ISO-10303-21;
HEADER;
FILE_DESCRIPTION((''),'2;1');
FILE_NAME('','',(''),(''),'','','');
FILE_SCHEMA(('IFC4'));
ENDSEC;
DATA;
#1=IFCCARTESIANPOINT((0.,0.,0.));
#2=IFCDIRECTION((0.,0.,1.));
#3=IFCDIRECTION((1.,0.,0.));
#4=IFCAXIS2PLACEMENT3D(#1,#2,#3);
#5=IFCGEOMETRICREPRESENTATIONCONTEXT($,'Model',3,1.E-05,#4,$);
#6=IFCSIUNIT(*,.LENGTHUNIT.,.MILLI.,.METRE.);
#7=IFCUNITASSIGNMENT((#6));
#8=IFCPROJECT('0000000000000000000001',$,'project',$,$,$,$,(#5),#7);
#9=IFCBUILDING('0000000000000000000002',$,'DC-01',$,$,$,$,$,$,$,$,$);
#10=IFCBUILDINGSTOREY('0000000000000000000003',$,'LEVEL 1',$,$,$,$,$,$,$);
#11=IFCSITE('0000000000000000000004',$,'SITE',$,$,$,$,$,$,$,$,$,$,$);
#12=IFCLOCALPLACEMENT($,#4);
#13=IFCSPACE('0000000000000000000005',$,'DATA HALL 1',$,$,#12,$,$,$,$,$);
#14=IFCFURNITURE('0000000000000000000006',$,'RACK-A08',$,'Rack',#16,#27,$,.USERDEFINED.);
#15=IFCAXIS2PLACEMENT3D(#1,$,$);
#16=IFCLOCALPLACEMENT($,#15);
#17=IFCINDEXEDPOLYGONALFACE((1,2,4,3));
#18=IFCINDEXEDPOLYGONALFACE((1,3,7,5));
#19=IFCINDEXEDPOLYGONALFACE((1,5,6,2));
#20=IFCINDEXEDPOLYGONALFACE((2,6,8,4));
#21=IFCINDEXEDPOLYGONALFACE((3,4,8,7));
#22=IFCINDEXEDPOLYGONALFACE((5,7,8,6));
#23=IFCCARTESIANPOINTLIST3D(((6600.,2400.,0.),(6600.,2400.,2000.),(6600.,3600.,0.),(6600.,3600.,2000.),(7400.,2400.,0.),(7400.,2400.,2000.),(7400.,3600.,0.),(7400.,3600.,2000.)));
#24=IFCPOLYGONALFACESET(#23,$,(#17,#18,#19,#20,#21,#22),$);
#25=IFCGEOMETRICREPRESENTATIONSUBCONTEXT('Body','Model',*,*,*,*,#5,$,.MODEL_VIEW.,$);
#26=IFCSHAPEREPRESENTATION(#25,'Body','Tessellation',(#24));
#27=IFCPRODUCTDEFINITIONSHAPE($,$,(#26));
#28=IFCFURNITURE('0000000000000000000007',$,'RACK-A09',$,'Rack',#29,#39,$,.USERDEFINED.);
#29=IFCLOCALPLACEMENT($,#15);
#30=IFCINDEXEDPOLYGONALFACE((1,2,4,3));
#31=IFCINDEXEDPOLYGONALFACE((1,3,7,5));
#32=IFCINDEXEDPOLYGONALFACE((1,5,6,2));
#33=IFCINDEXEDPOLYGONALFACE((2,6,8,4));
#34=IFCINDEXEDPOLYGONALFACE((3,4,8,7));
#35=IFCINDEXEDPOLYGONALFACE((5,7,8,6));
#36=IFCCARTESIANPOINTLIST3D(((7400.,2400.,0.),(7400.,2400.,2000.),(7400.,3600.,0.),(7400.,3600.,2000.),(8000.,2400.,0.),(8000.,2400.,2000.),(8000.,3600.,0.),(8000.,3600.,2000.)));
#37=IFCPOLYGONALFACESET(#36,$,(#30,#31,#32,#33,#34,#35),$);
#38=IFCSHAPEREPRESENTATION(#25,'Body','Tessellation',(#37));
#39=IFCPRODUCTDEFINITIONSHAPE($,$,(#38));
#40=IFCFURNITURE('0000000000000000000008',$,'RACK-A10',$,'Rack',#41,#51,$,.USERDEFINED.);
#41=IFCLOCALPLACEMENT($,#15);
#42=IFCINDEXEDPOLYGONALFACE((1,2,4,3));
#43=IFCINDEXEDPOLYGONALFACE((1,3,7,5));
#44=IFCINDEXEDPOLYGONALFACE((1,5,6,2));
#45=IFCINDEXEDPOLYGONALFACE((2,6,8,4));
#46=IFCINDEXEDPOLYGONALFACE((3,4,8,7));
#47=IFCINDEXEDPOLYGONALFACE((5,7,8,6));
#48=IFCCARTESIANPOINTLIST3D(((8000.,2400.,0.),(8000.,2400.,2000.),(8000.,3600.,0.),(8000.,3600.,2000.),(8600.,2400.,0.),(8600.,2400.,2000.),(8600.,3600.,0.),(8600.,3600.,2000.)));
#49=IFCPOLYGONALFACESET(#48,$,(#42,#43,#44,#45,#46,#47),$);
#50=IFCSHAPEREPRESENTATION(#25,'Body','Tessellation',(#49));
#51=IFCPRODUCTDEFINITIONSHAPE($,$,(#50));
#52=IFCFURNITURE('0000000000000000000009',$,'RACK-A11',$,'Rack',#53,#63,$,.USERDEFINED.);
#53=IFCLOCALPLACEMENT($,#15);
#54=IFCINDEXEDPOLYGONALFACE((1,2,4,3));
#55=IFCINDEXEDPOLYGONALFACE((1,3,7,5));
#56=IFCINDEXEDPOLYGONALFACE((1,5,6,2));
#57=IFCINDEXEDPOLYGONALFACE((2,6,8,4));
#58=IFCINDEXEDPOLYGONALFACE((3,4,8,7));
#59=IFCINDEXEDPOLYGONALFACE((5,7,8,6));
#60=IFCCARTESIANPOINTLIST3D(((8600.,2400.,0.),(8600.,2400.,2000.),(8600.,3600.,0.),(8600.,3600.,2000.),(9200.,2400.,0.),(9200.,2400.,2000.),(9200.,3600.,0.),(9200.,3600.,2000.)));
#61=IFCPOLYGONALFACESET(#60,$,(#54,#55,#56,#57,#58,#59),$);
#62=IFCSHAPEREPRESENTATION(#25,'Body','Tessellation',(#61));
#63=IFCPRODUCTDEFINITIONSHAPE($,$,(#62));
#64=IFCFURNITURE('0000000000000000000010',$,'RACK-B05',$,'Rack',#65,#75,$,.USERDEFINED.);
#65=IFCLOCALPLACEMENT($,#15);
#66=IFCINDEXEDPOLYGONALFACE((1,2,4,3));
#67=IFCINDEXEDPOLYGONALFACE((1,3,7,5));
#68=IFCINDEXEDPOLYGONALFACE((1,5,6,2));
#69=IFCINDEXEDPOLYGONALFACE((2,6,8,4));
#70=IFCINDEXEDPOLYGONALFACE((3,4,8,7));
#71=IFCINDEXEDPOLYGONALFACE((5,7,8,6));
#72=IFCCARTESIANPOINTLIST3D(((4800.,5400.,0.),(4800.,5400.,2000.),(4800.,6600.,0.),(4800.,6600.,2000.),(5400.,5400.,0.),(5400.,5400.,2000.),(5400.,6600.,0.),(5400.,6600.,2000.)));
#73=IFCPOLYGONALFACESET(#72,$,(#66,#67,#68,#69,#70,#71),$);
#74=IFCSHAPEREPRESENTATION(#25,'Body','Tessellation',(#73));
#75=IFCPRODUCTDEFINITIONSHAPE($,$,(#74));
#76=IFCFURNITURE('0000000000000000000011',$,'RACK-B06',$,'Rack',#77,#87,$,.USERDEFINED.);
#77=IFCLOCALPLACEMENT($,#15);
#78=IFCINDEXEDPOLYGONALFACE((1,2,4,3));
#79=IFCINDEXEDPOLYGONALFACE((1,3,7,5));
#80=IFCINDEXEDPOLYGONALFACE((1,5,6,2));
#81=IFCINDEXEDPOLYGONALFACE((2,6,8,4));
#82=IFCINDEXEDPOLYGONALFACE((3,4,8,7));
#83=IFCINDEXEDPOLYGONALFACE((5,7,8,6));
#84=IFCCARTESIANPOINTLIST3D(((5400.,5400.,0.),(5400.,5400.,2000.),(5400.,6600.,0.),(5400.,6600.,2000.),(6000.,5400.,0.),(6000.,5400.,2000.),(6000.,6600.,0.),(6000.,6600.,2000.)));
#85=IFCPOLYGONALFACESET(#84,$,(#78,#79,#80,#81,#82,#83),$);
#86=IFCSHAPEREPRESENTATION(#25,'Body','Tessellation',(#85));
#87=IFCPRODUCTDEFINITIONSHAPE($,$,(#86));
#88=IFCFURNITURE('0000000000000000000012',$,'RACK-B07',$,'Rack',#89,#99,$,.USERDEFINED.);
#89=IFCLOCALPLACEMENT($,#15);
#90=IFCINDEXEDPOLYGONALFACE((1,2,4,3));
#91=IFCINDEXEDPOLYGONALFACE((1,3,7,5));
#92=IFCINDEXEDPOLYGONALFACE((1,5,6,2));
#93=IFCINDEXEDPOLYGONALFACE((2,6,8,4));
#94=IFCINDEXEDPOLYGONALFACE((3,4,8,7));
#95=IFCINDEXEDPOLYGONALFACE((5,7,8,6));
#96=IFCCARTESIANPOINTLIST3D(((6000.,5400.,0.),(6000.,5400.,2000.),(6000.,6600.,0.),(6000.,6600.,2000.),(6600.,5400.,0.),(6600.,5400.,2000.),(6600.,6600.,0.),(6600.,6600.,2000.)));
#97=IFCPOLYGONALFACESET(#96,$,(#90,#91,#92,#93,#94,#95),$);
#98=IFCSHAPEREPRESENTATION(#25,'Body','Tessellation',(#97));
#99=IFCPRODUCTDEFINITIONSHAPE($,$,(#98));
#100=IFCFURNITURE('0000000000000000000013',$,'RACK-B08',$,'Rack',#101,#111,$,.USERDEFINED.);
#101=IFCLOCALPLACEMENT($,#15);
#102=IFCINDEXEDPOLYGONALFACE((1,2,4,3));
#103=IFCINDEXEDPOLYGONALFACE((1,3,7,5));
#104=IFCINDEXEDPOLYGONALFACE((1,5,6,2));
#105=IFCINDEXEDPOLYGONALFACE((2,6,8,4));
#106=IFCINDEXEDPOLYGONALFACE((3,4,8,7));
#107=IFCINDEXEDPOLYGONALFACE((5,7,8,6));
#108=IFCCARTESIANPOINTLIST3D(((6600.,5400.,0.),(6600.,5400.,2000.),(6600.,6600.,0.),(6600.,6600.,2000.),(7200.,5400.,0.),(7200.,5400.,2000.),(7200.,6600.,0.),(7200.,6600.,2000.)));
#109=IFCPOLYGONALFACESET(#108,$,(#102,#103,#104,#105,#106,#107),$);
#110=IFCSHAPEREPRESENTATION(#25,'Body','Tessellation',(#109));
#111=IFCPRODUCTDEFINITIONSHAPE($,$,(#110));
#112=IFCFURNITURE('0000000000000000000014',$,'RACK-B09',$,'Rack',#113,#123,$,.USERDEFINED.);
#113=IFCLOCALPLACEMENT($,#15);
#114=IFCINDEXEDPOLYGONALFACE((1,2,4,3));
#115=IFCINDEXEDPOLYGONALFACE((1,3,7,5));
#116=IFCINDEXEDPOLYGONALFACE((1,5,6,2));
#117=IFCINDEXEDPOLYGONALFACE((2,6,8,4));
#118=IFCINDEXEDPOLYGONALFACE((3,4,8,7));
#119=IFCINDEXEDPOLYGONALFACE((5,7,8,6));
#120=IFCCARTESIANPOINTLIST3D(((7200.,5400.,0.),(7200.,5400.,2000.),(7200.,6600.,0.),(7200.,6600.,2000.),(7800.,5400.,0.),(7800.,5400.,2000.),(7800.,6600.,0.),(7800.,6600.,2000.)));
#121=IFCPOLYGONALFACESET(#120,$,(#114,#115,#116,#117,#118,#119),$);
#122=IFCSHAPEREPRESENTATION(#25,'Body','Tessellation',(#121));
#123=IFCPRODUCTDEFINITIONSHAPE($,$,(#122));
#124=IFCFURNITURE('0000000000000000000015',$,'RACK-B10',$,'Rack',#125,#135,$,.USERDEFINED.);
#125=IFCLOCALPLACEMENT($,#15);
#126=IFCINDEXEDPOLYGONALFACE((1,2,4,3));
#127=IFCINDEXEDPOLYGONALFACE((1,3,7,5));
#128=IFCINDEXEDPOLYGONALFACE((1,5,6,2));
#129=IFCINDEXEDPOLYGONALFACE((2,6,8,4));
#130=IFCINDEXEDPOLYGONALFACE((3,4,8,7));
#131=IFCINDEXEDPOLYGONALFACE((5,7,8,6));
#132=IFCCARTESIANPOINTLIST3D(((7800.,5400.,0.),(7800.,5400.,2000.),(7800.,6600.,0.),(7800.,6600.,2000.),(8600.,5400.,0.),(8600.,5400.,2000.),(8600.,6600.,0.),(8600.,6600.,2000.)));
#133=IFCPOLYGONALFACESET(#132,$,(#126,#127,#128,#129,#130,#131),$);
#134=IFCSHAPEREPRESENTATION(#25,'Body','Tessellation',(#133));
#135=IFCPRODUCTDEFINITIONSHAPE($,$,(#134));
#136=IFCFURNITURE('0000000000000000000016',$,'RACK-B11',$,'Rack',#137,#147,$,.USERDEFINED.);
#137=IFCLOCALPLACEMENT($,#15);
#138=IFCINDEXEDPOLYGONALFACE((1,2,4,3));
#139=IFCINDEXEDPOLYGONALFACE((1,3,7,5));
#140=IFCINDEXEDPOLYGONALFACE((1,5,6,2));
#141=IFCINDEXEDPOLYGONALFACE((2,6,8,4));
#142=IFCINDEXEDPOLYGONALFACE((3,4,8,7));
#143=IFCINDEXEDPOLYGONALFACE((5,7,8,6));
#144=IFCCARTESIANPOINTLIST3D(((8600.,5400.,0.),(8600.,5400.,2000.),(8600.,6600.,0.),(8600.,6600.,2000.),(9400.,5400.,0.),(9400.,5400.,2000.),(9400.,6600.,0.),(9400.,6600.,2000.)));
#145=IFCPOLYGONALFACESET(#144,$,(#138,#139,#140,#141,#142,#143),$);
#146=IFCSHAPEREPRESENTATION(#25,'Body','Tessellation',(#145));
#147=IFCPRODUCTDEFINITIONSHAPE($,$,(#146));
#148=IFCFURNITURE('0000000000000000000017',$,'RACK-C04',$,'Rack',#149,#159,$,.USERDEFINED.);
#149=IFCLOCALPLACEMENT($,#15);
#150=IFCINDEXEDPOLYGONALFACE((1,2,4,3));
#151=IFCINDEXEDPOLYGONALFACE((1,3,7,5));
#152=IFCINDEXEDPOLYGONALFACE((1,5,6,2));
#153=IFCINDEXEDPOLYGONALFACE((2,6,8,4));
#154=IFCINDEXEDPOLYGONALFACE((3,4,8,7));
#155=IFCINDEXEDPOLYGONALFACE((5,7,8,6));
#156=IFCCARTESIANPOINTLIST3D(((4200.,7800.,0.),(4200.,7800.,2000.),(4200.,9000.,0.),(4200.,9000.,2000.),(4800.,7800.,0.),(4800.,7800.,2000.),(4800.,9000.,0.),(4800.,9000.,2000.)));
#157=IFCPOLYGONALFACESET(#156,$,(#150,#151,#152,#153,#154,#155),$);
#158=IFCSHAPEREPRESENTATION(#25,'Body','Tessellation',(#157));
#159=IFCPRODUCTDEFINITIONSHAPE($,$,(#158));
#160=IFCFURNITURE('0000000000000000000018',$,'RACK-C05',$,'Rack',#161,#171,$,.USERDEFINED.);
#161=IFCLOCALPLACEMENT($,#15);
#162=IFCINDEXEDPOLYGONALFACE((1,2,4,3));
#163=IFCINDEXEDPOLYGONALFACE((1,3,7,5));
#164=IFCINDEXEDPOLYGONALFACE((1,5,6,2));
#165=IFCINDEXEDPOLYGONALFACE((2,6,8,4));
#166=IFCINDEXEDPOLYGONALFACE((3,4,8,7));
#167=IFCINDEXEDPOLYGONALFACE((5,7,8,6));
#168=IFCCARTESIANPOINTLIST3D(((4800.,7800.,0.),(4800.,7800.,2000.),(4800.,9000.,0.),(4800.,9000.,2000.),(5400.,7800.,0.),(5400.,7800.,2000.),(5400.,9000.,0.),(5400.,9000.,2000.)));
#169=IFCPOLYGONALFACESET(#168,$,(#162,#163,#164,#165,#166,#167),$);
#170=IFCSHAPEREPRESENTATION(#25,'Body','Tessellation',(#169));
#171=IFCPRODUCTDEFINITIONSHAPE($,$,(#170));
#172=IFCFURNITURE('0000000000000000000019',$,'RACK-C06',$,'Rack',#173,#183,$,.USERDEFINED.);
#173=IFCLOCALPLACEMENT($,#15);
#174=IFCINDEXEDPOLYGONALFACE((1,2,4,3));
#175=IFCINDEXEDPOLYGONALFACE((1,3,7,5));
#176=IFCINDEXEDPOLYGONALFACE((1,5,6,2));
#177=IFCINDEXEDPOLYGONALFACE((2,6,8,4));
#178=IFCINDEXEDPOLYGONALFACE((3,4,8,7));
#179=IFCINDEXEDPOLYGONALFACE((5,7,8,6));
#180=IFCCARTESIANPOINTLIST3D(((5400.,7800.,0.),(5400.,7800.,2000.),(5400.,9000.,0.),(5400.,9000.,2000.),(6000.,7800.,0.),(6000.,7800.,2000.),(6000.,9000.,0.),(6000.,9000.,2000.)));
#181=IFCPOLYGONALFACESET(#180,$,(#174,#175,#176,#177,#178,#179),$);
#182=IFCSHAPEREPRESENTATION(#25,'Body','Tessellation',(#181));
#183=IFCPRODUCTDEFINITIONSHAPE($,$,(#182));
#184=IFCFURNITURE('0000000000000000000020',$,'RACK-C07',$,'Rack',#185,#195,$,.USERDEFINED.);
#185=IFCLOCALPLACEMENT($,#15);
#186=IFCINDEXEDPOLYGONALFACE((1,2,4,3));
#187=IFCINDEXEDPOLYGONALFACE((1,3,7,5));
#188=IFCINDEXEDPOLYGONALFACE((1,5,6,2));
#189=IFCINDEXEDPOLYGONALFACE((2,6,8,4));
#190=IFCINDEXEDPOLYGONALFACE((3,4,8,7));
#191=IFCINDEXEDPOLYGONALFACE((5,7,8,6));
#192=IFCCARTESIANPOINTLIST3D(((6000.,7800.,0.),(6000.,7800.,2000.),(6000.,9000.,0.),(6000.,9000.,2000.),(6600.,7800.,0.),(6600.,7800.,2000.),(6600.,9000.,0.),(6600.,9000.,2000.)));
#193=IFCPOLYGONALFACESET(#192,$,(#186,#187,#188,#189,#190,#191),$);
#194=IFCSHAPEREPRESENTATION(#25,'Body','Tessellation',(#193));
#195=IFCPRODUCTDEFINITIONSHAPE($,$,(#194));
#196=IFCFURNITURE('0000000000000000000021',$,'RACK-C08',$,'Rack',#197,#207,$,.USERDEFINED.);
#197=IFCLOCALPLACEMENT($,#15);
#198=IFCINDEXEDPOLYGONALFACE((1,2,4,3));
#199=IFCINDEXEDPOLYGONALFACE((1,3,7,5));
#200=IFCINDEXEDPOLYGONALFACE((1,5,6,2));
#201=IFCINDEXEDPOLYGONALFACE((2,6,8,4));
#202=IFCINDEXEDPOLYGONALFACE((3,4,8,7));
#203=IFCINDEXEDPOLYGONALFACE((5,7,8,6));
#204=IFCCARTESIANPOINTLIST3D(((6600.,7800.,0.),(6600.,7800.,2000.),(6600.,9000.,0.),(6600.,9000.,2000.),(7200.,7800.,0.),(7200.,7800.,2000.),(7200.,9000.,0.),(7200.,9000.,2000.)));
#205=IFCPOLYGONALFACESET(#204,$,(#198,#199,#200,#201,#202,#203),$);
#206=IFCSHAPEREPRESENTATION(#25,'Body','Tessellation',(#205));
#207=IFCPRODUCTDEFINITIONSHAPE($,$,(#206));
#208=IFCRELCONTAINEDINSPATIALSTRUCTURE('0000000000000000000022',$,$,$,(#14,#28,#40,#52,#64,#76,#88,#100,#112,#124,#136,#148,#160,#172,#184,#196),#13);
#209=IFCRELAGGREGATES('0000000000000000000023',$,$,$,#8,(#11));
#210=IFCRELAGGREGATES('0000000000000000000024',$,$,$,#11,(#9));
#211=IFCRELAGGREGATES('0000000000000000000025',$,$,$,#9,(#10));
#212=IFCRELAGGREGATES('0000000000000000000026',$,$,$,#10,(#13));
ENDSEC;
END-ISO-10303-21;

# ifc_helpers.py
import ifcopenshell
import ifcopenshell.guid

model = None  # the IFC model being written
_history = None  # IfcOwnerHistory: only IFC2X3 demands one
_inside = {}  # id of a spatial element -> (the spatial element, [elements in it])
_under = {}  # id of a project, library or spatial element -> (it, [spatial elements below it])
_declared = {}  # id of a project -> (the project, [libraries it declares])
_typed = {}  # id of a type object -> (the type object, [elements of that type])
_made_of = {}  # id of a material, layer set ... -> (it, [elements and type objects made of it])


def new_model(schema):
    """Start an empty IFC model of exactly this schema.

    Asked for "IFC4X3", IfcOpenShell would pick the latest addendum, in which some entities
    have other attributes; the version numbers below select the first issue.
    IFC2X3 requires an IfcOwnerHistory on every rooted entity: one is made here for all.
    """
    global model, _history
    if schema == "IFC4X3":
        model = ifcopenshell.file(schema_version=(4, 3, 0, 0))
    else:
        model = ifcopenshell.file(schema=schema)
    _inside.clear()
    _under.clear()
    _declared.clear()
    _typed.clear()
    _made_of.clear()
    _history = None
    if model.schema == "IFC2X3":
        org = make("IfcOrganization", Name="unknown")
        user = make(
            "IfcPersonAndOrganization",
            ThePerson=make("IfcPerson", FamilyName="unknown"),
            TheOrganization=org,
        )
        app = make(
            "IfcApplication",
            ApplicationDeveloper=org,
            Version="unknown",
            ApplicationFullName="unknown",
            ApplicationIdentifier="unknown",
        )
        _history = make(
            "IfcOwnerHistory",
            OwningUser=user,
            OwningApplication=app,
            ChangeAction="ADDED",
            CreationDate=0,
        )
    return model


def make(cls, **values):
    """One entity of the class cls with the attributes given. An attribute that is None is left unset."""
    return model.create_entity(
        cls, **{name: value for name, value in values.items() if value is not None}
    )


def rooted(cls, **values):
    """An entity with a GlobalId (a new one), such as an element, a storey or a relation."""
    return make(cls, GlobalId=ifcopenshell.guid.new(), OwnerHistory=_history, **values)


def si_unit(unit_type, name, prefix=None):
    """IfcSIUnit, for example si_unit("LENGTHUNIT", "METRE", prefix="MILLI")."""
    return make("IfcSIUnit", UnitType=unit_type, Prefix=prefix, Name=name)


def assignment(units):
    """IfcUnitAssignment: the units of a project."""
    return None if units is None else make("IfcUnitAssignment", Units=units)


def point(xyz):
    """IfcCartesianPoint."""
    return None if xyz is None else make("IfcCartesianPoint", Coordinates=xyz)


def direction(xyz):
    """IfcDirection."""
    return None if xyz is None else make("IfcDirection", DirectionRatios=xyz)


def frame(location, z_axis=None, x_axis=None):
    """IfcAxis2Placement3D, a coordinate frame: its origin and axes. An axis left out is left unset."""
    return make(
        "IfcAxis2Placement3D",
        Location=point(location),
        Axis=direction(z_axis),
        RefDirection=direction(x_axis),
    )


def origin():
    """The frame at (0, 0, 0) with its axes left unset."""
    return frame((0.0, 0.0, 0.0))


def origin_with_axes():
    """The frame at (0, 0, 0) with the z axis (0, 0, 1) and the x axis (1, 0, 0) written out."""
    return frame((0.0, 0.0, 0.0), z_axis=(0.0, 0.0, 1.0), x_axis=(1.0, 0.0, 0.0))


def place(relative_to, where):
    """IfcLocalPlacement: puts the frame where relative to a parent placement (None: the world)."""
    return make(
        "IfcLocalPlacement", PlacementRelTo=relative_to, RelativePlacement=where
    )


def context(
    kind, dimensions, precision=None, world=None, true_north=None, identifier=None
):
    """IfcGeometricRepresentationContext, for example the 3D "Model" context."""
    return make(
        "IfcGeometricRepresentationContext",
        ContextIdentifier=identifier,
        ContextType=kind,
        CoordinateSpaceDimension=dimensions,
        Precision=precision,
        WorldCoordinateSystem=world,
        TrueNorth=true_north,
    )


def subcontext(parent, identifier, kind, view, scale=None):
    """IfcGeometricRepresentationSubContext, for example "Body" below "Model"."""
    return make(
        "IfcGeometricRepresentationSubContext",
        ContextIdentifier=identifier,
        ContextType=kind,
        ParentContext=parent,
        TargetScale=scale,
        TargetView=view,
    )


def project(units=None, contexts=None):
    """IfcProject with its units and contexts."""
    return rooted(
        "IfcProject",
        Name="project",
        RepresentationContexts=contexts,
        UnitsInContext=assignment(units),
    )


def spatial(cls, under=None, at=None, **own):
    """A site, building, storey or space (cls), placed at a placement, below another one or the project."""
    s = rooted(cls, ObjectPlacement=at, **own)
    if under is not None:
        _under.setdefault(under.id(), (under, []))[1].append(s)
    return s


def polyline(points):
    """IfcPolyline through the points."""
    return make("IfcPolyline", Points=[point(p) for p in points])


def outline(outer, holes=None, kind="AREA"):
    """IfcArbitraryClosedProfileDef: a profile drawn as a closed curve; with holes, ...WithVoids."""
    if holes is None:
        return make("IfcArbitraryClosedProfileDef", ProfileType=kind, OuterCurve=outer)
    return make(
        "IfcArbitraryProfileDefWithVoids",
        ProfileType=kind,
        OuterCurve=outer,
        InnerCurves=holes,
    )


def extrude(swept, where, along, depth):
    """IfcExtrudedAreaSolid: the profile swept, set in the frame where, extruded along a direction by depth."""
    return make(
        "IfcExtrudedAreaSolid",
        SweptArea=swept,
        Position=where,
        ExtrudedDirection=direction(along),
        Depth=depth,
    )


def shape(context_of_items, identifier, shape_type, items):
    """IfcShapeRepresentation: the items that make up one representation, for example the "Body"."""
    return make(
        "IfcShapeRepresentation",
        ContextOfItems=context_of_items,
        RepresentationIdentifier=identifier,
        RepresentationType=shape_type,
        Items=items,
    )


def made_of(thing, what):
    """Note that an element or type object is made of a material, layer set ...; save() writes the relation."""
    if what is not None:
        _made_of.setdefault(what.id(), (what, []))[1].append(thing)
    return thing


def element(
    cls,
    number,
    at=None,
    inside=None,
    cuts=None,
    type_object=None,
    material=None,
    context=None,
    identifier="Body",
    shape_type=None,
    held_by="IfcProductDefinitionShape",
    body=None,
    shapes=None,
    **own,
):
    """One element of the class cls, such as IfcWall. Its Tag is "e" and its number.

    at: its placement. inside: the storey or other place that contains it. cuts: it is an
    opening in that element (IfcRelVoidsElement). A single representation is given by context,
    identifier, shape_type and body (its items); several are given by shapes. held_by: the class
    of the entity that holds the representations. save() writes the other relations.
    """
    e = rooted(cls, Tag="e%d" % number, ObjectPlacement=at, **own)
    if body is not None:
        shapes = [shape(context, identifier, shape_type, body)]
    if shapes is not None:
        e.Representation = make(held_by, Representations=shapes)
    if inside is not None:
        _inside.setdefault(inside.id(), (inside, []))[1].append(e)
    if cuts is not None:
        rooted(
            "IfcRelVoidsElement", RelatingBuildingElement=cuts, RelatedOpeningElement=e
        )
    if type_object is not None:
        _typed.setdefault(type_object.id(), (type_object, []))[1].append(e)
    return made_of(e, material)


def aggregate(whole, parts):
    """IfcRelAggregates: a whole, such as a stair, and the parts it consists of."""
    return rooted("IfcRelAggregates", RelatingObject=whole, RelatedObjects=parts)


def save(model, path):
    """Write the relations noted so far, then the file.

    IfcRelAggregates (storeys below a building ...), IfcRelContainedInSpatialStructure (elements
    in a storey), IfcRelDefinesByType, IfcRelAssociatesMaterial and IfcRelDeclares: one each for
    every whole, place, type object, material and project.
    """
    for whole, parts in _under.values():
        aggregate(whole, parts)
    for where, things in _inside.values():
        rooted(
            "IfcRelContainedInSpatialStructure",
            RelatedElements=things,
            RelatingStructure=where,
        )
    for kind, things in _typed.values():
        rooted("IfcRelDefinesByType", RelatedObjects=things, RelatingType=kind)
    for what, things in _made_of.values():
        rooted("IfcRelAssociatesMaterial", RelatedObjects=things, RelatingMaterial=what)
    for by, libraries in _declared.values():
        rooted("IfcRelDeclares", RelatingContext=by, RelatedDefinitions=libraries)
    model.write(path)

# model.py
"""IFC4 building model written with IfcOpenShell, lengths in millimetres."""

from ifc_helpers import new_model, si_unit, frame, origin, origin_with_axes, place, context, subcontext, project, spatial, polyline, outline, extrude, element, save


model = new_model("IFC4")

# Units and contexts
model_context = context("Model", 3, precision=1e-05, world=origin_with_axes())
body_context = subcontext(model_context, "Body", "Model", "MODEL_VIEW")
ifc_project = project(units=[si_unit("LENGTHUNIT", "METRE", prefix="MILLI")], contexts=[model_context])

# Site, building, storey, space
site = spatial("IfcSite", under=ifc_project, Name="SITE")
building = spatial("IfcBuilding", under=site, Name="DC-01")
storey = spatial("IfcBuildingStorey", under=building, Name="LEVEL 1")
space_placement = place(None, origin_with_axes())
space = spatial("IfcSpace", under=storey, at=space_placement, Name="DATA HALL 1")

# Furniture
furniture_placement = place(space_placement, frame((7400.0, 3600.0, 0.0), z_axis=(0.0, 0.0, 1.0), x_axis=(-1.0, 0.0, 0.0)))
element("IfcFurniture", 1, at=furniture_placement, inside=space, Name="RACK-A08", ObjectType="Rack", PredefinedType="USERDEFINED", context=body_context, shape_type="SweptSolid", body=[
    extrude(outline(polyline([(0.0, 0.0), (800.0, 0.0), (800.0, 1200.0), (0.0, 1200.0), (0.0, 0.0)])), origin(), (0.0, 0.0, 1.0), 2000.0),
])
for number, where, z_axis, x_axis, name in (
    (2, (8000.0, 3600.0, 0.0), (0.0, 0.0, 1.0), (-1.0, 0.0, 0.0), "RACK-A09"),
    (3, (8600.0, 3600.0, 0.0), (0.0, 0.0, 1.0), (-1.0, 0.0, 0.0), "RACK-A10"),
    (4, (9200.0, 3600.0, 0.0), (0.0, 0.0, 1.0), (-1.0, 0.0, 0.0), "RACK-A11"),
    (5, (4800.0, 5400.0, 0.0), (0.0, 0.0, 1.0), (1.0, 0.0, 0.0), "RACK-B05"),
    (6, (5400.0, 5400.0, 0.0), (0.0, 0.0, 1.0), (1.0, 0.0, 0.0), "RACK-B06"),
    (7, (6000.0, 5400.0, 0.0), (0.0, 0.0, 1.0), (1.0, 0.0, 0.0), "RACK-B07"),
    (8, (6600.0, 5400.0, 0.0), (0.0, 0.0, 1.0), (1.0, 0.0, 0.0), "RACK-B08"),
    (9, (7200.0, 5400.0, 0.0), (0.0, 0.0, 1.0), (1.0, 0.0, 0.0), "RACK-B09"),
):
    element("IfcFurniture", number, at=place(space_placement, frame(where, z_axis=z_axis, x_axis=x_axis)), inside=space, Name=name, ObjectType="Rack", PredefinedType="USERDEFINED", context=body_context, shape_type="SweptSolid", body=[
        extrude(outline(polyline([(0.0, 0.0), (600.0, 0.0), (600.0, 1200.0), (0.0, 1200.0), (0.0, 0.0)])), origin(), (0.0, 0.0, 1.0), 2000.0),
    ])
for number, where, z_axis, x_axis, name in (
    (10, (7800.0, 5400.0, 0.0), (0.0, 0.0, 1.0), (1.0, 0.0, 0.0), "RACK-B10"),
    (11, (8600.0, 5400.0, 0.0), (0.0, 0.0, 1.0), (1.0, 0.0, 0.0), "RACK-B11"),
):
    element("IfcFurniture", number, at=place(space_placement, frame(where, z_axis=z_axis, x_axis=x_axis)), inside=space, Name=name, ObjectType="Rack", PredefinedType="USERDEFINED", context=body_context, shape_type="SweptSolid", body=[
        extrude(outline(polyline([(0.0, 0.0), (800.0, 0.0), (800.0, 1200.0), (0.0, 1200.0), (0.0, 0.0)])), origin(), (0.0, 0.0, 1.0), 2000.0),
    ])
for number, where, z_axis, x_axis, name in (
    (12, (4800.0, 9000.0, 0.0), (0.0, 0.0, 1.0), (-1.0, 0.0, 0.0), "RACK-C04"),
    (13, (5400.0, 9000.0, 0.0), (0.0, 0.0, 1.0), (-1.0, 0.0, 0.0), "RACK-C05"),
    (14, (6000.0, 9000.0, 0.0), (0.0, 0.0, 1.0), (-1.0, 0.0, 0.0), "RACK-C06"),
    (15, (6600.0, 9000.0, 0.0), (0.0, 0.0, 1.0), (-1.0, 0.0, 0.0), "RACK-C07"),
    (16, (7200.0, 9000.0, 0.0), (0.0, 0.0, 1.0), (-1.0, 0.0, 0.0), "RACK-C08"),
):
    element("IfcFurniture", number, at=place(space_placement, frame(where, z_axis=z_axis, x_axis=x_axis)), inside=space, Name=name, ObjectType="Rack", PredefinedType="USERDEFINED", context=body_context, shape_type="SweptSolid", body=[
        extrude(outline(polyline([(0.0, 0.0), (600.0, 0.0), (600.0, 1200.0), (0.0, 1200.0), (0.0, 0.0)])), origin(), (0.0, 0.0, 1.0), 2000.0),
    ])

save(model, "model.ifc")
